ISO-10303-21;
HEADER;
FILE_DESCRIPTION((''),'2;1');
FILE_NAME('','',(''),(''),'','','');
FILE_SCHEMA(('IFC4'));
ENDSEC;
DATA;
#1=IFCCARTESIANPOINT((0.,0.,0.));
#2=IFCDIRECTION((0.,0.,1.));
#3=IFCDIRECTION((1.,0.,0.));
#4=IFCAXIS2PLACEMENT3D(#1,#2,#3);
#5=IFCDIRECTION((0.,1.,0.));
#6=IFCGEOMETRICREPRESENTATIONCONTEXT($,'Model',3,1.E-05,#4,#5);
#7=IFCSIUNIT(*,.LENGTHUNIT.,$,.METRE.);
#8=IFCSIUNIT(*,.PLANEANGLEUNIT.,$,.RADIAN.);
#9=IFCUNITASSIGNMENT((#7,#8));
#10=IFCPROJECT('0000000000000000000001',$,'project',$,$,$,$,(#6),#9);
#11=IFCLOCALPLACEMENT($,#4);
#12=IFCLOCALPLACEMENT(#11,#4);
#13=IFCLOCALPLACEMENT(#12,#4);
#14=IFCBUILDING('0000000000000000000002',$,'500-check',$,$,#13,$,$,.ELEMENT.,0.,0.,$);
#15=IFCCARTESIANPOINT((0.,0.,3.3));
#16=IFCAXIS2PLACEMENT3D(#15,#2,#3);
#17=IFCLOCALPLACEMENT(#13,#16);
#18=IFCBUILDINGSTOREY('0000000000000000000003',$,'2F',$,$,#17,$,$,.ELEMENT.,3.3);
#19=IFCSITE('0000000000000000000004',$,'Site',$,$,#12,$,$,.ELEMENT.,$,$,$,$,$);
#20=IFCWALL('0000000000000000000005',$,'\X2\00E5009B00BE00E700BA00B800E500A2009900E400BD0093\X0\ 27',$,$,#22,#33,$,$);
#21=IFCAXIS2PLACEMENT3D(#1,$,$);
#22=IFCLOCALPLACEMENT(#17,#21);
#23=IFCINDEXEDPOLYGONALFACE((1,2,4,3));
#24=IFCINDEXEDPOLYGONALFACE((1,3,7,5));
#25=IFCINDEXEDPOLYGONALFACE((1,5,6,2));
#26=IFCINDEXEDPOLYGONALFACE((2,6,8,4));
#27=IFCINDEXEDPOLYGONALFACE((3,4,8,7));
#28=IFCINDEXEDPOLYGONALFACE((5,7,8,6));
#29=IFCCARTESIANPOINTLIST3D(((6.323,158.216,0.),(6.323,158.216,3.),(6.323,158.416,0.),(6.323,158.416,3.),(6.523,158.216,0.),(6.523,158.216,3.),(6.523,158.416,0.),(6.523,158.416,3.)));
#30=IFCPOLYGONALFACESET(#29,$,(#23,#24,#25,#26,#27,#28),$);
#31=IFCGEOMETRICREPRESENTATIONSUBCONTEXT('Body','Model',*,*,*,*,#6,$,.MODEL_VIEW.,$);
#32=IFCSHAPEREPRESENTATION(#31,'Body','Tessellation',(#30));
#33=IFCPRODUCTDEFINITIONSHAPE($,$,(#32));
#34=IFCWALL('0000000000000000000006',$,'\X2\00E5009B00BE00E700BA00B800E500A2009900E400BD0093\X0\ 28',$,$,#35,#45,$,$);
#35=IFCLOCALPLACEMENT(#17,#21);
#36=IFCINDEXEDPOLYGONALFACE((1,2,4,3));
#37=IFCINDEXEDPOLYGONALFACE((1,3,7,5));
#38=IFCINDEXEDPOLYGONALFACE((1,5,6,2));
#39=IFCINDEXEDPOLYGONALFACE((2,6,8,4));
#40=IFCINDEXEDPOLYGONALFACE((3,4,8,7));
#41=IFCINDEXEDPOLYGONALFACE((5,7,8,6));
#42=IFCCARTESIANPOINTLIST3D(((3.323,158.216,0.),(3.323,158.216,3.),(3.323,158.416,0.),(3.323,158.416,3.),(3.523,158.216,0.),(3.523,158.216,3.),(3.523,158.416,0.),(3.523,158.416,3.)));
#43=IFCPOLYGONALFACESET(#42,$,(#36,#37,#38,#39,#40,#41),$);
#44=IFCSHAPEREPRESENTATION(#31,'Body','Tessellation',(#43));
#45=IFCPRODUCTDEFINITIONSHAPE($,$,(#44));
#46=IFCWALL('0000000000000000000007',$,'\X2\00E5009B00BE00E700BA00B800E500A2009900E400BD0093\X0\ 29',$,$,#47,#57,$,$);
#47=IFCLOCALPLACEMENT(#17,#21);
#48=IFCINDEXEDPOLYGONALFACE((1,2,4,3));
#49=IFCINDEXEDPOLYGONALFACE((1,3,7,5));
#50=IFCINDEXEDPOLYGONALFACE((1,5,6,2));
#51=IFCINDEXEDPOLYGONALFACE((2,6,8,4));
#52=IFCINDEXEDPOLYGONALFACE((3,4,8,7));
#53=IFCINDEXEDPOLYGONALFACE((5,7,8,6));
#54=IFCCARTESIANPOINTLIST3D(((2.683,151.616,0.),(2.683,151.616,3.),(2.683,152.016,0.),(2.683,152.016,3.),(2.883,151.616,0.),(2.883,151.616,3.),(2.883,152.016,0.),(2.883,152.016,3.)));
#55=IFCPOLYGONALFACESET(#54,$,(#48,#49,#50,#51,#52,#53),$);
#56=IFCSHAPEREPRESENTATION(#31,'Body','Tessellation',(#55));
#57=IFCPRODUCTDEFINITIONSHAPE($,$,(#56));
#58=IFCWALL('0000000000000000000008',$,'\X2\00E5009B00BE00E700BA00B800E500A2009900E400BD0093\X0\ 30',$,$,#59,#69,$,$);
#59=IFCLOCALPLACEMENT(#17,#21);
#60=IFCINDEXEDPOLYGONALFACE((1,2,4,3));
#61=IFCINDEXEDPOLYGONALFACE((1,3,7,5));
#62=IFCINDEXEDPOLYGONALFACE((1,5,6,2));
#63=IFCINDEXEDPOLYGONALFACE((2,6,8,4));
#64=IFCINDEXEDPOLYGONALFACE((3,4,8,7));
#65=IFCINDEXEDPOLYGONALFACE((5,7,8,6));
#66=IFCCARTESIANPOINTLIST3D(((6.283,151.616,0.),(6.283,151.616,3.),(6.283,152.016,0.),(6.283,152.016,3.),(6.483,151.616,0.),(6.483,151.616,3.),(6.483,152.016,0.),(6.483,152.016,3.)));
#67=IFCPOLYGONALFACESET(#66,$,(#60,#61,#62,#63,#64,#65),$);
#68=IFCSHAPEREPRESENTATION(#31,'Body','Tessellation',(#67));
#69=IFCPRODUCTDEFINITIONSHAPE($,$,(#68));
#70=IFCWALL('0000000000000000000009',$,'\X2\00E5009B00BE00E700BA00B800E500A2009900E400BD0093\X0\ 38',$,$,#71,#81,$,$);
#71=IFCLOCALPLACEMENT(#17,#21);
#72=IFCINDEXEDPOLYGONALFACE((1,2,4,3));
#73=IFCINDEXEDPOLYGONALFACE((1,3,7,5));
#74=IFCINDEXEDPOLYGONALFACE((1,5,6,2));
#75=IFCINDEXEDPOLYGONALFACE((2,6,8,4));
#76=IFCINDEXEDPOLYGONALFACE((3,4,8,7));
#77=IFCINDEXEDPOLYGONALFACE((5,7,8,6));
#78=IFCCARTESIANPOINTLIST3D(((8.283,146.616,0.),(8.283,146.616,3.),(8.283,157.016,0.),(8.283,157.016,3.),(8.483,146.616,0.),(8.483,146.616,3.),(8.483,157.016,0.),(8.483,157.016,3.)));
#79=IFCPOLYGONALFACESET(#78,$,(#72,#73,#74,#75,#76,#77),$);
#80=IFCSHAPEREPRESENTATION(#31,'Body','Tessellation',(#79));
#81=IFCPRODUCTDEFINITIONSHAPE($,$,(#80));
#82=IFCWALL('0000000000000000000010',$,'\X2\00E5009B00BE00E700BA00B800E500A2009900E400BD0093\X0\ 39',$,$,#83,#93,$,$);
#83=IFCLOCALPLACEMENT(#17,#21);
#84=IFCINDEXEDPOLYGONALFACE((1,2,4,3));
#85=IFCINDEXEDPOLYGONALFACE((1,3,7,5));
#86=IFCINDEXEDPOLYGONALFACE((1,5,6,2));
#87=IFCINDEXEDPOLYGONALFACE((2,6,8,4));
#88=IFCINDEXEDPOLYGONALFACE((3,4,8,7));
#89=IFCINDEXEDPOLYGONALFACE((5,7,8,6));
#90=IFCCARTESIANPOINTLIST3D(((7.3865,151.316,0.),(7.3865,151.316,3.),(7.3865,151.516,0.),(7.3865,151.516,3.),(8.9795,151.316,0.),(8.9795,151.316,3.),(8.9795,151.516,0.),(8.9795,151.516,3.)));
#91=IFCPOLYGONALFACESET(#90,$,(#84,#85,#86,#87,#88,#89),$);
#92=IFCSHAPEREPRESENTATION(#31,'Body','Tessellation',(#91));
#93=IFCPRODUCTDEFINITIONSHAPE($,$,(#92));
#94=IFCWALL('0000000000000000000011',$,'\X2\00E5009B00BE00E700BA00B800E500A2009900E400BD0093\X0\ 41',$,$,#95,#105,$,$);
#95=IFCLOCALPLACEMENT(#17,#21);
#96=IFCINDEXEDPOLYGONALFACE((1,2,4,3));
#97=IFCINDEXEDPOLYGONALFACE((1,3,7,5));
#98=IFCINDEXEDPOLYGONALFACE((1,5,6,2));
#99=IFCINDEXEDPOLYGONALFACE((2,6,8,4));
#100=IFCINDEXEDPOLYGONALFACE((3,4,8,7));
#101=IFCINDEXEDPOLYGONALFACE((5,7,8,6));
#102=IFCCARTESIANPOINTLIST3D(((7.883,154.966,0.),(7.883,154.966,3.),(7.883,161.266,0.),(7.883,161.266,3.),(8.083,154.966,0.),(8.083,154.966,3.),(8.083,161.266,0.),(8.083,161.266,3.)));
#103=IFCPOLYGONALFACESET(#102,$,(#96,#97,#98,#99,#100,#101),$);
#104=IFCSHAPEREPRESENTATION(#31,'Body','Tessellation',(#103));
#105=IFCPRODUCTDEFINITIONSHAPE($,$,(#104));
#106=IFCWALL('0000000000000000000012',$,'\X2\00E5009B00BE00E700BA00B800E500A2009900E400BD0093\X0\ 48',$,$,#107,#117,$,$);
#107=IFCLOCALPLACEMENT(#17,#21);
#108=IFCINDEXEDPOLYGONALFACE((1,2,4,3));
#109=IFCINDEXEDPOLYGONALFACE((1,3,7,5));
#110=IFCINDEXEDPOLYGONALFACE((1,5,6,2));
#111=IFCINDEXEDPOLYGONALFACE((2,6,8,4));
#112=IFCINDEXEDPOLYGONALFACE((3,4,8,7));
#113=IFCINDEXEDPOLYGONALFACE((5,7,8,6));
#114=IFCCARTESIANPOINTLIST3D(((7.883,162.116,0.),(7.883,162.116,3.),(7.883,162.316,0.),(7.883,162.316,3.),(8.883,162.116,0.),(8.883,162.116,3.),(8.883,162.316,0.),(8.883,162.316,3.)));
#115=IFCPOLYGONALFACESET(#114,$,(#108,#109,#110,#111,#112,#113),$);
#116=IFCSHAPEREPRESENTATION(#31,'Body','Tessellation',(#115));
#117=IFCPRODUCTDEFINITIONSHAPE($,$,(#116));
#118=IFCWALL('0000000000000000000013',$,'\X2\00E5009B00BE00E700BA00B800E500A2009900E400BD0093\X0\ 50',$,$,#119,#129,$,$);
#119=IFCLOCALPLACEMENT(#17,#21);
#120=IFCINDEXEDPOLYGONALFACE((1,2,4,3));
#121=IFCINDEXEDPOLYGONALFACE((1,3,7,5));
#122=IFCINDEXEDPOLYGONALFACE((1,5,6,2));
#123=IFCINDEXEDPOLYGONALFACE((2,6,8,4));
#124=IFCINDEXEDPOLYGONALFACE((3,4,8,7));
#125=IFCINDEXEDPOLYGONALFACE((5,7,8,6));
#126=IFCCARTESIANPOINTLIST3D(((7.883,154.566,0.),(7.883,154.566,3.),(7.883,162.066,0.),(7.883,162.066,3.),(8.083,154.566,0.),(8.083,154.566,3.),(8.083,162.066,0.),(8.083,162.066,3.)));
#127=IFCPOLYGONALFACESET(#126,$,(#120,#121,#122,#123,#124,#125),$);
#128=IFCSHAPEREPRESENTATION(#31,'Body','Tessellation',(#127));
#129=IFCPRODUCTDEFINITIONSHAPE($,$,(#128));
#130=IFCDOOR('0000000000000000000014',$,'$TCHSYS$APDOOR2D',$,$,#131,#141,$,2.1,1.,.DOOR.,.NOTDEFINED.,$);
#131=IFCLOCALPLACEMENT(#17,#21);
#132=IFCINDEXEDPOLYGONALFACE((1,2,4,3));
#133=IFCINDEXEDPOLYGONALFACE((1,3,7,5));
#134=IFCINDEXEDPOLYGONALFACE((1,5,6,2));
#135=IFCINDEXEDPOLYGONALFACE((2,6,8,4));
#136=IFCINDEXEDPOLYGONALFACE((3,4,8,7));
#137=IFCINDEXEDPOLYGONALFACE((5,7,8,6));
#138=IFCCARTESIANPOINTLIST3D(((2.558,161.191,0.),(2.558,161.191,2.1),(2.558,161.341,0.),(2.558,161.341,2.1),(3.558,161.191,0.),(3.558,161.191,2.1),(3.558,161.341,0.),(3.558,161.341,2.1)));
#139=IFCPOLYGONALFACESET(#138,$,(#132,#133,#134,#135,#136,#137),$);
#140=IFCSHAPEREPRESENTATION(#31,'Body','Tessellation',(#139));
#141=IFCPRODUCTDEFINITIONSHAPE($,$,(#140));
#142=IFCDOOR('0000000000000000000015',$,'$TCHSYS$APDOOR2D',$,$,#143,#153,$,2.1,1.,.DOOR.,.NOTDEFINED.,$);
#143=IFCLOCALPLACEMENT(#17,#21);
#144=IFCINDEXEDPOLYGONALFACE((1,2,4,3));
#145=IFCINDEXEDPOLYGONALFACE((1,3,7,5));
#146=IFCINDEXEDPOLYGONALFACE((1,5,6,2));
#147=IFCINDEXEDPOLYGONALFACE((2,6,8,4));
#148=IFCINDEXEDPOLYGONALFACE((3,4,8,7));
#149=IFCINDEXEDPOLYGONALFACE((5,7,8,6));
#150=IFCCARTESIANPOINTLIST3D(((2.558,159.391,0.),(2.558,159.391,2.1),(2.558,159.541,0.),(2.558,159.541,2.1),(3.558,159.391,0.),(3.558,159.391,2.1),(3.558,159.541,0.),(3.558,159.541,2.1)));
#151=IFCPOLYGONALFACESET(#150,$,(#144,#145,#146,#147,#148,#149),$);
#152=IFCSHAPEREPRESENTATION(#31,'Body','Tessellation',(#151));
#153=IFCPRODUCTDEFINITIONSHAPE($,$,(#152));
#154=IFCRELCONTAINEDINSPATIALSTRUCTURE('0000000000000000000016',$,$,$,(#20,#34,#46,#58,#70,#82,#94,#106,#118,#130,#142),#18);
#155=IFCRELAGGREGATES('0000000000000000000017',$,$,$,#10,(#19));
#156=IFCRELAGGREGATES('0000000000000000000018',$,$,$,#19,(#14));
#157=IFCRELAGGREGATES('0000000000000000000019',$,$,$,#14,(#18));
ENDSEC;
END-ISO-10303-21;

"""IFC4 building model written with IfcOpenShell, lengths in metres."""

from ifc_helpers import new_model, si_unit, direction, frame, frame_2d, origin_with_axes, place, context, subcontext, project, spatial, rectangle, extrude, element, save


model = new_model("IFC4")

# Units and contexts
model_context = context("Model", 3, precision=1e-05, world=origin_with_axes(), true_north=direction((0.0, 1.0, 0.0)))
body_context = subcontext(model_context, "Body", "Model", "MODEL_VIEW")
ifc_project = project(units=[si_unit("LENGTHUNIT", "METRE"), si_unit("PLANEANGLEUNIT", "RADIAN")], contexts=[model_context])

# Site, building, storey
placement = place(None, origin_with_axes())
site_placement = place(placement, origin_with_axes())
site = spatial("IfcSite", under=ifc_project, at=site_placement, Name="Site", CompositionType="ELEMENT")
building_placement = place(site_placement, origin_with_axes())
building = spatial("IfcBuilding", under=site, at=building_placement, Name="500-check", CompositionType="ELEMENT", ElevationOfRefHeight=0.0, ElevationOfTerrain=0.0)
storey_placement = place(building_placement, frame((0.0, 0.0, 3.3), z_axis=(0.0, 0.0, 1.0), x_axis=(1.0, 0.0, 0.0)))
storey = spatial("IfcBuildingStorey", under=building, at=storey_placement, Name="2F", CompositionType="ELEMENT", Elevation=3.3)

# Walls
for number, where, z_axis, x_axis, name in (
    (1, (6.423, 158.316, 0.0), (0.0, 0.0, 1.0), (0.0, -1.0, 0.0), "å\u009b¾çº¸å¢\u0099ä½\u0093 27"),
    (2, (3.423, 158.316, 0.0), (0.0, 0.0, 1.0), (0.0, -1.0, 0.0), "å\u009b¾çº¸å¢\u0099ä½\u0093 28"),
):
    element("IfcWall", number, at=place(storey_placement, frame(where, z_axis=z_axis, x_axis=x_axis)), inside=storey, Name=name, context=body_context, shape_type="SweptSolid", body=[
        extrude(rectangle(XDim=0.2, YDim=0.2, at=frame_2d((0.0, 0.0), x_axis=(1.0, 0.0, 0.0))), frame((0.0, 0.0, 0.0), z_axis=(0.0, 0.0, 1.0)), (0.0, 0.0, 1.0), 3.0),
    ])
for number, where, z_axis, x_axis, name in (
    (3, (2.783, 151.816, 0.0), (0.0, 0.0, 1.0), (0.0, -1.0, 0.0), "å\u009b¾çº¸å¢\u0099ä½\u0093 29"),
    (4, (6.383, 151.816, 0.0), (0.0, 0.0, 1.0), (0.0, -1.0, 0.0), "å\u009b¾çº¸å¢\u0099ä½\u0093 30"),
):
    element("IfcWall", number, at=place(storey_placement, frame(where, z_axis=z_axis, x_axis=x_axis)), inside=storey, Name=name, context=body_context, shape_type="SweptSolid", body=[
        extrude(rectangle(XDim=0.4, YDim=0.2, at=frame_2d((0.0, 0.0), x_axis=(1.0, 0.0, 0.0))), frame((0.0, 0.0, 0.0), z_axis=(0.0, 0.0, 1.0)), (0.0, 0.0, 1.0), 3.0),
    ])
wall_1_placement = place(storey_placement, frame((8.383, 151.816, 0.0), z_axis=(0.0, 0.0, 1.0), x_axis=(0.0, 1.0, 0.0)))
element("IfcWall", 5, at=wall_1_placement, inside=storey, Name="å\u009b¾çº¸å¢\u0099ä½\u0093 38", context=body_context, shape_type="SweptSolid", body=[
    extrude(rectangle(XDim=10.4, YDim=0.2, at=frame_2d((0.0, 0.0), x_axis=(1.0, 0.0, 0.0))), frame((0.0, 0.0, 0.0), z_axis=(0.0, 0.0, 1.0)), (0.0, 0.0, 1.0), 3.0),
])
wall_2_placement = place(storey_placement, frame((8.183, 151.416, 0.0), z_axis=(0.0, 0.0, 1.0), x_axis=(1.0, 0.0, 0.0)))
element("IfcWall", 6, at=wall_2_placement, inside=storey, Name="å\u009b¾çº¸å¢\u0099ä½\u0093 39", context=body_context, shape_type="SweptSolid", body=[
    extrude(rectangle(XDim=1.593, YDim=0.2, at=frame_2d((0.0, 0.0), x_axis=(1.0, 0.0, 0.0))), frame((0.0, 0.0, 0.0), z_axis=(0.0, 0.0, 1.0)), (0.0, 0.0, 1.0), 3.0),
])
wall_3_placement = place(storey_placement, frame((7.983, 158.116, 0.0), z_axis=(0.0, 0.0, 1.0), x_axis=(0.0, -1.0, 0.0)))
element("IfcWall", 7, at=wall_3_placement, inside=storey, Name="å\u009b¾çº¸å¢\u0099ä½\u0093 41", context=body_context, shape_type="SweptSolid", body=[
    extrude(rectangle(XDim=6.3, YDim=0.2, at=frame_2d((0.0, 0.0), x_axis=(1.0, 0.0, 0.0))), frame((0.0, 0.0, 0.0), z_axis=(0.0, 0.0, 1.0)), (0.0, 0.0, 1.0), 3.0),
])
wall_4_placement = place(storey_placement, frame((8.383, 162.216, 0.0), z_axis=(0.0, 0.0, 1.0), x_axis=(1.0, 0.0, 0.0)))
element("IfcWall", 8, at=wall_4_placement, inside=storey, Name="å\u009b¾çº¸å¢\u0099ä½\u0093 48", context=body_context, shape_type="SweptSolid", body=[
    extrude(rectangle(XDim=1.0, YDim=0.2, at=frame_2d((0.0, 0.0), x_axis=(1.0, 0.0, 0.0))), frame((0.0, 0.0, 0.0), z_axis=(0.0, 0.0, 1.0)), (0.0, 0.0, 1.0), 3.0),
])
wall_5_placement = place(storey_placement, frame((7.983, 158.316, 0.0), z_axis=(0.0, 0.0, 1.0), x_axis=(0.0, 1.0, 0.0)))
element("IfcWall", 9, at=wall_5_placement, inside=storey, Name="å\u009b¾çº¸å¢\u0099ä½\u0093 50", context=body_context, shape_type="SweptSolid", body=[
    extrude(rectangle(XDim=7.5, YDim=0.2, at=frame_2d((0.0, 0.0), x_axis=(1.0, 0.0, 0.0))), frame((0.0, 0.0, 0.0), z_axis=(0.0, 0.0, 1.0)), (0.0, 0.0, 1.0), 3.0),
])

# Doors
for number, where, z_axis, x_axis, name in (
    (10, (3.058, 161.266, 0.0), (0.0, 0.0, 1.0), (1.0, 0.0, 0.0), "$TCHSYS$APDOOR2D"),
    (11, (3.058, 159.466, 0.0), (0.0, 0.0, 1.0), (1.0, 0.0, 0.0), "$TCHSYS$APDOOR2D"),
):
    element("IfcDoor", number, at=place(storey_placement, frame(where, z_axis=z_axis, x_axis=x_axis)), inside=storey, Name=name, OperationType="NOTDEFINED", OverallHeight=2.1, OverallWidth=1.0, PredefinedType="DOOR", context=body_context, shape_type="SweptSolid", body=[
        extrude(rectangle(XDim=1.0, YDim=0.15, at=frame_2d((0.0, 0.0), x_axis=(1.0, 0.0, 0.0))), frame((0.0, 0.0, 0.0), z_axis=(0.0, 0.0, 1.0)), (0.0, 0.0, 1.0), 2.1),
    ])

save(model, "model.ifc")
